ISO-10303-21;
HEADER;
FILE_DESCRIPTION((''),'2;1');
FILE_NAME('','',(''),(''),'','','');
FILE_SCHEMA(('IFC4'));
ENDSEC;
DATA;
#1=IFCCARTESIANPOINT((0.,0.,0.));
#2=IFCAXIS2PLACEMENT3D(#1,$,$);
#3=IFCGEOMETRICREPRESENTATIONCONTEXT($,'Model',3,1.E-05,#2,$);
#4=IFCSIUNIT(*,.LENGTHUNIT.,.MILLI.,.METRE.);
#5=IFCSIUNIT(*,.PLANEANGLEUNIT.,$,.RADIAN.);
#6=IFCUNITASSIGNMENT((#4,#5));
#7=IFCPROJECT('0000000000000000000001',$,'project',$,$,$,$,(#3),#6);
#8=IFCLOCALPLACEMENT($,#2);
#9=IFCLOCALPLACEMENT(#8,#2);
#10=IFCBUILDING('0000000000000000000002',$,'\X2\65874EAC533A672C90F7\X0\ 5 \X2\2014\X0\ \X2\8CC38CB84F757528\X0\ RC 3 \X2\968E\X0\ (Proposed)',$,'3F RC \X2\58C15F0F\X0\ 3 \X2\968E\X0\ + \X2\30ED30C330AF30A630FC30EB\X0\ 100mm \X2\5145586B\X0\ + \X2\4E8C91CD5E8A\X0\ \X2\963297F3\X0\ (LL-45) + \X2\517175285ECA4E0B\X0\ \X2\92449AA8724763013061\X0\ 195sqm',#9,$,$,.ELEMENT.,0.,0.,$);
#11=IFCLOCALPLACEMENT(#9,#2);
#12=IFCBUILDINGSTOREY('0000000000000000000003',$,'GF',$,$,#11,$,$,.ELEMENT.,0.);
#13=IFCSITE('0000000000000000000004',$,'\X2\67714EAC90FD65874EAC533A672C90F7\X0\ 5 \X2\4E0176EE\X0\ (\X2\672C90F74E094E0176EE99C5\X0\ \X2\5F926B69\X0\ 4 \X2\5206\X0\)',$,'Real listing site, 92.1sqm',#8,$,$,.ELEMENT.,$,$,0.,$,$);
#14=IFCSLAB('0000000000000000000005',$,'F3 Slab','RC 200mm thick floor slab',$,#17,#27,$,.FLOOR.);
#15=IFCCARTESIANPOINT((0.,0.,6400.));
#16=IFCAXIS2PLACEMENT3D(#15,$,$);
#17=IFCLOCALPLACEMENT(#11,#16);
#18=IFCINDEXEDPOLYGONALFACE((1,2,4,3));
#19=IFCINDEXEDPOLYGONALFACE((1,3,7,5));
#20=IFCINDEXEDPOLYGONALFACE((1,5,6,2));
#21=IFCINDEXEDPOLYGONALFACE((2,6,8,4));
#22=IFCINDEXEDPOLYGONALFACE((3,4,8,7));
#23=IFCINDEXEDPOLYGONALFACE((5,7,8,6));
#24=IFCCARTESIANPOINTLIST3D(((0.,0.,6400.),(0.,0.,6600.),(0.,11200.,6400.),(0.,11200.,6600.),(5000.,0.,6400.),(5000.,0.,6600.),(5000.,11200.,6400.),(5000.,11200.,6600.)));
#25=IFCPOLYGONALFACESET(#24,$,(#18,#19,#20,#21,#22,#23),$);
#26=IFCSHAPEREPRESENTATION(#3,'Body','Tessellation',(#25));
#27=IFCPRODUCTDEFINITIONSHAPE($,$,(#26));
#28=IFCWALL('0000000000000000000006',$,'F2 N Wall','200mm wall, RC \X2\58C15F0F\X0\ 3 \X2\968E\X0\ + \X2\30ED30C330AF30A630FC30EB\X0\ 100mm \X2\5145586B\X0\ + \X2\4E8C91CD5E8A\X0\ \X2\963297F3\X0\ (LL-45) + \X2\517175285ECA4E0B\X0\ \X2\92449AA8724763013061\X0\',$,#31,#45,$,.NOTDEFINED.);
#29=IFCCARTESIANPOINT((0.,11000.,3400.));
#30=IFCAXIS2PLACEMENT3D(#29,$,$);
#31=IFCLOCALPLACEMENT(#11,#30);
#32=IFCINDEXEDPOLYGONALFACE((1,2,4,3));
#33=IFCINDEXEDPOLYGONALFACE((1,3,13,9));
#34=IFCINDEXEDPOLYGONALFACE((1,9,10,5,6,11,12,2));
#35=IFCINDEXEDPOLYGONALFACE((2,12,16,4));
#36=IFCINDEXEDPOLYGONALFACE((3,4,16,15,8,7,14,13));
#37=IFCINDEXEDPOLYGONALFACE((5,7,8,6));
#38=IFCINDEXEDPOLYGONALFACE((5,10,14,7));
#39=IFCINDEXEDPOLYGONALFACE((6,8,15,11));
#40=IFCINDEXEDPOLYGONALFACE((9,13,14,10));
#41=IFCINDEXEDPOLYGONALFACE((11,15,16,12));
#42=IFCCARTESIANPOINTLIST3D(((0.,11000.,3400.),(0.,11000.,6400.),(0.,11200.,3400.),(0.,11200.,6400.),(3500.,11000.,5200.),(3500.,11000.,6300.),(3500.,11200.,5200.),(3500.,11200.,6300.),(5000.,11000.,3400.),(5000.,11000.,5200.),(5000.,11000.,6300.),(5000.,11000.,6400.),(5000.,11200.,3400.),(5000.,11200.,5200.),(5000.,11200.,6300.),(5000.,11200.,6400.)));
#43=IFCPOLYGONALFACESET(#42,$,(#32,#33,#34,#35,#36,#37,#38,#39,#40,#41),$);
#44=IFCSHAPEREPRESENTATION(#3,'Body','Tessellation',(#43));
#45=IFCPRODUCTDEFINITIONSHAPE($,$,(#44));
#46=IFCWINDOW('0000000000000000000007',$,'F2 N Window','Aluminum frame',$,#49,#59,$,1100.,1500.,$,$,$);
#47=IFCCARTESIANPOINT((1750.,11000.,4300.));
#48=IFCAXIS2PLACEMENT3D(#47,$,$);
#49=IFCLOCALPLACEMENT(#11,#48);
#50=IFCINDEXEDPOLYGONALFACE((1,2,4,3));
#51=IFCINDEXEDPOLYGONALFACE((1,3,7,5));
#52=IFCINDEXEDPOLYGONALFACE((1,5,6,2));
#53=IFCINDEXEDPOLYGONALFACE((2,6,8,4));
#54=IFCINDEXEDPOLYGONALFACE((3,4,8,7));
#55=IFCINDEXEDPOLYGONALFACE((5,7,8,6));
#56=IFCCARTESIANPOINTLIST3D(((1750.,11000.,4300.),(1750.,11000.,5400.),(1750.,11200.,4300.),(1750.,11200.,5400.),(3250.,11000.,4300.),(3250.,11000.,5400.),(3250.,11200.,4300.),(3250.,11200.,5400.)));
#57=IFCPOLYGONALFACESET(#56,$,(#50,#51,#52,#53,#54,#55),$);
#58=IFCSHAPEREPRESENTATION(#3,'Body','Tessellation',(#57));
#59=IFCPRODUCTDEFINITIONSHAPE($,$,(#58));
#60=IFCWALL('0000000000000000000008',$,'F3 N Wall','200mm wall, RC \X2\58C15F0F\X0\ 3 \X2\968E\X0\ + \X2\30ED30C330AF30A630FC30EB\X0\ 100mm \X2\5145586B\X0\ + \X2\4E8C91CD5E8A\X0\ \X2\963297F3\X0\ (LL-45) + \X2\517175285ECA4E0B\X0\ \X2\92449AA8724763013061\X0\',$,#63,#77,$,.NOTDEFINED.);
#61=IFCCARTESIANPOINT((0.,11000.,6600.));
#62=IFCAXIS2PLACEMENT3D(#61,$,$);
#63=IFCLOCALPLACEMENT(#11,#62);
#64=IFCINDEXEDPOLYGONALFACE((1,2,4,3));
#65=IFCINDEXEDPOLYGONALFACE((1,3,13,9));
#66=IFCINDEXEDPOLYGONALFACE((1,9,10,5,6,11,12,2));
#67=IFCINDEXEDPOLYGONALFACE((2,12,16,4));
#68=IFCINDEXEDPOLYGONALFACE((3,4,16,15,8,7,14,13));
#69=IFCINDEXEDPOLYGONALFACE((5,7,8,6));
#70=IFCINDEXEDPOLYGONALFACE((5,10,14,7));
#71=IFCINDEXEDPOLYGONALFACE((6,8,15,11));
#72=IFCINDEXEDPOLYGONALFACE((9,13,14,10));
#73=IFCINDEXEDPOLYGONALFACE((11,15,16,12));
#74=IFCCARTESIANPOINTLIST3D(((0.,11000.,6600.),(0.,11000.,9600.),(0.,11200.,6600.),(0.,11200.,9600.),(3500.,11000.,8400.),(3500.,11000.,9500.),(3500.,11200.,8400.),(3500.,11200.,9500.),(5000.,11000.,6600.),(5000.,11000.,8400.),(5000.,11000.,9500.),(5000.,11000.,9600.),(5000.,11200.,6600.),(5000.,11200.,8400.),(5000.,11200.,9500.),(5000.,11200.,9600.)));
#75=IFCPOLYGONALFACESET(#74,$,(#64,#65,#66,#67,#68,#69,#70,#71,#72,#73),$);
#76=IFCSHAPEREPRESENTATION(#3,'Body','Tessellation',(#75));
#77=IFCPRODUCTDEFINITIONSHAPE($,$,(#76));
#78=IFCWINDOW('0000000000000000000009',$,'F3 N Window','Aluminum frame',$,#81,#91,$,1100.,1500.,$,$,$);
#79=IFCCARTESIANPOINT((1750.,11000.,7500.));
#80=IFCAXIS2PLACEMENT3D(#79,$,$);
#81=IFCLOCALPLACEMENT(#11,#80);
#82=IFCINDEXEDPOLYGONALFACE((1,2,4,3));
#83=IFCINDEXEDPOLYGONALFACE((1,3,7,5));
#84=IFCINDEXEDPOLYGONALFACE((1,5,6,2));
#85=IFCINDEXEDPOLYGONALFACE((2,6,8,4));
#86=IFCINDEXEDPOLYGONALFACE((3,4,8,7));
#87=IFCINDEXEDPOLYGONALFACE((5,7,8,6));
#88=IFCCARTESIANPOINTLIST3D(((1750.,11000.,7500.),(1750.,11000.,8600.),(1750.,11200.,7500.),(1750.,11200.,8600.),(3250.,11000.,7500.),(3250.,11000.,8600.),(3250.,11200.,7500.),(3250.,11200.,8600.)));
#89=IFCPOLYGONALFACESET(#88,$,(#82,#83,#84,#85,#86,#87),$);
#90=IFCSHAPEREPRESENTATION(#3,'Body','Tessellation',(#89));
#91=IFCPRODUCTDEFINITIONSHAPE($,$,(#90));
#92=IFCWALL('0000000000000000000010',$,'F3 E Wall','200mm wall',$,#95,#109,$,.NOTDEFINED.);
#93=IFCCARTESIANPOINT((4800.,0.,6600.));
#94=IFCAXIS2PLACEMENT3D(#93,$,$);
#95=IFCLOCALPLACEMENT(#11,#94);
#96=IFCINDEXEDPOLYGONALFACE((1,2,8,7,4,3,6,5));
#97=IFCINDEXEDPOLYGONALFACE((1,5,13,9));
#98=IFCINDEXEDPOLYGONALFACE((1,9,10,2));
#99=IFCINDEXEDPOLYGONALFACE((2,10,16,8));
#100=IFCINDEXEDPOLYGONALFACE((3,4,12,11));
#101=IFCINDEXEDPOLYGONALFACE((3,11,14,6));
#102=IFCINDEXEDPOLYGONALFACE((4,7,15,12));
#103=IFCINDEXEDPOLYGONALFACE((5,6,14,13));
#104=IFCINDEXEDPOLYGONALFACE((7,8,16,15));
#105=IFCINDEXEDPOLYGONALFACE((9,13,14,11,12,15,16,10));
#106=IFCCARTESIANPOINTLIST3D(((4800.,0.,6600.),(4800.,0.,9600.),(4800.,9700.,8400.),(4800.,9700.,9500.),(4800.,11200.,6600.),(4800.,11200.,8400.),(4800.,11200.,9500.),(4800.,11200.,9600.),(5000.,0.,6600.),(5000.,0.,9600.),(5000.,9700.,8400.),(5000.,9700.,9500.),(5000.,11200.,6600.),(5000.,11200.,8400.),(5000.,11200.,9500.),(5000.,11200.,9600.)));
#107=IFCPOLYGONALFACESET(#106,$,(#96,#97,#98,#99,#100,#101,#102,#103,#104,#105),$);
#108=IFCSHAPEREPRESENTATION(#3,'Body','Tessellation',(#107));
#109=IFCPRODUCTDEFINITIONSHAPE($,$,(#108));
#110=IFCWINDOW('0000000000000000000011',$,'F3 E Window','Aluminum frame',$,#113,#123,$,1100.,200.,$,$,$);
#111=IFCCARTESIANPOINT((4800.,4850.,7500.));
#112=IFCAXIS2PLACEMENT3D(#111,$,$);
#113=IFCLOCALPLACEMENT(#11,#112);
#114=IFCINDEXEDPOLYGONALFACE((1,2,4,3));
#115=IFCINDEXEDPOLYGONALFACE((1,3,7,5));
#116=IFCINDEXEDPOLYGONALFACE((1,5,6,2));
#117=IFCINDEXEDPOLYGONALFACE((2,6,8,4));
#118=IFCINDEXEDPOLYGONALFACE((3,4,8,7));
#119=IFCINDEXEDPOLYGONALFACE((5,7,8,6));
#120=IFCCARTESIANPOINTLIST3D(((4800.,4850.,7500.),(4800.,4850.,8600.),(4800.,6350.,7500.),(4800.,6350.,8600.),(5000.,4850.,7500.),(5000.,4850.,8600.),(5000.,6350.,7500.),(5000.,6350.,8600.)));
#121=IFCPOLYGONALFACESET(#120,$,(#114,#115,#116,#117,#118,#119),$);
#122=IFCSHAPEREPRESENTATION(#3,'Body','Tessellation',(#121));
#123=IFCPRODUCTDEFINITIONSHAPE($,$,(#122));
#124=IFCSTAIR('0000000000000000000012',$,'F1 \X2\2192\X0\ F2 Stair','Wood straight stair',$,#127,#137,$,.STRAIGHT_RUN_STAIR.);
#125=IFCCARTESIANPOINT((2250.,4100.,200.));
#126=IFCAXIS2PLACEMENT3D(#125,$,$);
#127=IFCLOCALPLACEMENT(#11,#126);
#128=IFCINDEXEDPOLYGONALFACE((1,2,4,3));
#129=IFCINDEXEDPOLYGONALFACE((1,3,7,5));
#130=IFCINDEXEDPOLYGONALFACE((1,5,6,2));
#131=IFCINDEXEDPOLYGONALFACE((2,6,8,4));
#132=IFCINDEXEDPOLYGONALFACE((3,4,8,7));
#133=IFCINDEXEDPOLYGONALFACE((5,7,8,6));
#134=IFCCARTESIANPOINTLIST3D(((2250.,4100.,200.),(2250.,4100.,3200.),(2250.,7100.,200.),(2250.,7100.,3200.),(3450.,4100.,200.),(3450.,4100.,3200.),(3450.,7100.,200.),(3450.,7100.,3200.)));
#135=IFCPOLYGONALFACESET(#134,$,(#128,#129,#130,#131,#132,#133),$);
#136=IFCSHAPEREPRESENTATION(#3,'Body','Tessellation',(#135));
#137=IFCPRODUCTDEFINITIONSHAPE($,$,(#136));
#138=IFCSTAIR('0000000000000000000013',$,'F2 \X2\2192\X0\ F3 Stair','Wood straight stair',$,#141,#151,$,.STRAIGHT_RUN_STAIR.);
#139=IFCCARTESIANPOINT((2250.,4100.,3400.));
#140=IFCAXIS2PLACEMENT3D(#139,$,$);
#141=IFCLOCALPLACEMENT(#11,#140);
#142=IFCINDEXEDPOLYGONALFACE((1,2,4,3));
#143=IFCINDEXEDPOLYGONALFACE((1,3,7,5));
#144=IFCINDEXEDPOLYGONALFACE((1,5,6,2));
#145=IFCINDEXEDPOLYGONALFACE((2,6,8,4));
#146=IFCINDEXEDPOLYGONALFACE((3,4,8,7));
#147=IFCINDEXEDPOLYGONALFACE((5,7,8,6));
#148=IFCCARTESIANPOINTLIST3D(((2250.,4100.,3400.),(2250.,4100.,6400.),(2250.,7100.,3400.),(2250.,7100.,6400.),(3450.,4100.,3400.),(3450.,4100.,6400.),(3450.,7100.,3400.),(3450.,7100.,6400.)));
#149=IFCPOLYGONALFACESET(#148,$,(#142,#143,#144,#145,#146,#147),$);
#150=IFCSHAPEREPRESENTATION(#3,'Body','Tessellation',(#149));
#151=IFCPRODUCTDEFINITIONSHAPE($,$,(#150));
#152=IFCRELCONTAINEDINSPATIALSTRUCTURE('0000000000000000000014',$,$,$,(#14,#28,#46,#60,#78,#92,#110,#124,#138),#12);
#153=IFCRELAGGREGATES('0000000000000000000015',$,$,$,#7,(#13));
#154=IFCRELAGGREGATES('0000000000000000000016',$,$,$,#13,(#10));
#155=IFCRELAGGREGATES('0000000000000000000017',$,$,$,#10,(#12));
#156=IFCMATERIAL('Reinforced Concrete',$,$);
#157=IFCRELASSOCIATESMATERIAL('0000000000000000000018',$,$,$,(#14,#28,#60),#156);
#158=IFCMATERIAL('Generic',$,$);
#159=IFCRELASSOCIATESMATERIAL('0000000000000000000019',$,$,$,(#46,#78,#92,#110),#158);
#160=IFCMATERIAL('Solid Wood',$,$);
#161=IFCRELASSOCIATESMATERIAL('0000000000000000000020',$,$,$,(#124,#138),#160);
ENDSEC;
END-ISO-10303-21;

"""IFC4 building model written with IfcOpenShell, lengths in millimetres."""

from ifc_helpers import new_model, si_unit, frame, frame_2d, origin, place, context, project, spatial, rectangle, extrude, material, element, fill, save


model = new_model("IFC4")

# Units and contexts
model_context = context("Model", 3, precision=1e-05, world=origin())
ifc_project = project(units=[si_unit("LENGTHUNIT", "METRE", prefix="MILLI"), si_unit("PLANEANGLEUNIT", "RADIAN")], contexts=[model_context])

# Site, building, storey
site_placement = place(None, origin())
site = spatial("IfcSite", under=ifc_project, at=site_placement, Name="東京都文京区本郷 5 丁目 (本郷三丁目駅 徒歩 4 分)", ObjectType="Real listing site, 92.1sqm", CompositionType="ELEMENT", RefElevation=0.0)
building_placement = place(site_placement, origin())
building = spatial("IfcBuilding", under=site, at=building_placement, Name="文京区本郷 5 — 賃貸併用 RC 3 階 (Proposed)", ObjectType="3F RC 壁式 3 階 + ロックウール 100mm 充填 + 二重床 防音 (LL-45) + 共用廊下 鉄骨片持ち 195sqm", CompositionType="ELEMENT", ElevationOfRefHeight=0.0, ElevationOfTerrain=0.0)
storey_placement = place(building_placement, origin())
storey = spatial("IfcBuildingStorey", under=building, at=storey_placement, Name="GF", CompositionType="ELEMENT", Elevation=0.0)

# Slab
ifc_material_1 = material(Name="Reinforced Concrete")
slab_placement = place(storey_placement, frame((0.0, 0.0, 6400.0)))
element("IfcSlab", 1, at=slab_placement, inside=storey, material=ifc_material_1, Name="F3 Slab", Description="RC 200mm thick floor slab", PredefinedType="FLOOR", context=model_context, shape_type="SweptSolid", body=[
    extrude(rectangle(XDim=5000.0, YDim=11200.0, at=frame_2d((2500.0, 5600.0))), frame((0.0, 0.0, 6400.0)), (0.0, 0.0, 1.0), 200.0),
])

# Walls, openings, windows
ifc_material_2 = material(Name="Generic")
wall_1_placement = place(storey_placement, frame((0.0, 11000.0, 3400.0)))
wall_1 = element("IfcWall", 2, at=wall_1_placement, inside=storey, material=ifc_material_1, Name="F2 N Wall", Description="200mm wall, RC 壁式 3 階 + ロックウール 100mm 充填 + 二重床 防音 (LL-45) + 共用廊下 鉄骨片持ち", PredefinedType="NOTDEFINED", context=model_context, shape_type="SweptSolid", body=[
    extrude(rectangle(XDim=5000.0, YDim=200.0, at=frame_2d((2500.0, 100.0))), frame((0.0, 11000.0, 3400.0)), (0.0, 0.0, 1.0), 3000.0),
])
opening_1_placement = place(storey_placement, frame((1750.0, 11000.0, 4300.0)))
opening_1 = element("IfcOpeningElement", 3, at=opening_1_placement, cuts=wall_1, PredefinedType="NOTDEFINED", context=model_context, shape_type="SweptSolid", body=[
    extrude(rectangle(XDim=1500.0, YDim=200.0, at=frame_2d((750.0, 100.0))), frame((1750.0, 11000.0, 4300.0)), (0.0, 0.0, 1.0), 1100.0),
])
window_1_placement = place(storey_placement, frame((1750.0, 11000.0, 4300.0)))
window_1 = element("IfcWindow", 4, at=window_1_placement, inside=storey, material=ifc_material_2, Name="F2 N Window", Description="Aluminum frame", OverallHeight=1100.0, OverallWidth=1500.0, context=model_context, shape_type="SweptSolid", body=[
    extrude(rectangle(XDim=1500.0, YDim=200.0, at=frame_2d((750.0, 100.0))), frame((1750.0, 11000.0, 4300.0)), (0.0, 0.0, 1.0), 1100.0),
])
fill(opening_1, window_1)
wall_2_placement = place(storey_placement, frame((0.0, 11000.0, 6600.0)))
wall_2 = element("IfcWall", 5, at=wall_2_placement, inside=storey, material=ifc_material_1, Name="F3 N Wall", Description="200mm wall, RC 壁式 3 階 + ロックウール 100mm 充填 + 二重床 防音 (LL-45) + 共用廊下 鉄骨片持ち", PredefinedType="NOTDEFINED", context=model_context, shape_type="SweptSolid", body=[
    extrude(rectangle(XDim=5000.0, YDim=200.0, at=frame_2d((2500.0, 100.0))), frame((0.0, 11000.0, 6600.0)), (0.0, 0.0, 1.0), 3000.0),
])
opening_2_placement = place(storey_placement, frame((1750.0, 11000.0, 7500.0)))
opening_2 = element("IfcOpeningElement", 6, at=opening_2_placement, cuts=wall_2, PredefinedType="NOTDEFINED", context=model_context, shape_type="SweptSolid", body=[
    extrude(rectangle(XDim=1500.0, YDim=200.0, at=frame_2d((750.0, 100.0))), frame((1750.0, 11000.0, 7500.0)), (0.0, 0.0, 1.0), 1100.0),
])
window_2_placement = place(storey_placement, frame((1750.0, 11000.0, 7500.0)))
window_2 = element("IfcWindow", 7, at=window_2_placement, inside=storey, material=ifc_material_2, Name="F3 N Window", Description="Aluminum frame", OverallHeight=1100.0, OverallWidth=1500.0, context=model_context, shape_type="SweptSolid", body=[
    extrude(rectangle(XDim=1500.0, YDim=200.0, at=frame_2d((750.0, 100.0))), frame((1750.0, 11000.0, 7500.0)), (0.0, 0.0, 1.0), 1100.0),
])
fill(opening_2, window_2)
wall_3_placement = place(storey_placement, frame((4800.0, 0.0, 6600.0)))
wall_3 = element("IfcWall", 8, at=wall_3_placement, inside=storey, material=ifc_material_2, Name="F3 E Wall", Description="200mm wall", PredefinedType="NOTDEFINED", context=model_context, shape_type="SweptSolid", body=[
    extrude(rectangle(XDim=200.0, YDim=11200.0, at=frame_2d((100.0, 5600.0))), frame((4800.0, 0.0, 6600.0)), (0.0, 0.0, 1.0), 3000.0),
])
opening_3_placement = place(storey_placement, frame((4800.0, 4850.0, 7500.0)))
opening_3 = element("IfcOpeningElement", 9, at=opening_3_placement, cuts=wall_3, PredefinedType="NOTDEFINED", context=model_context, shape_type="SweptSolid", body=[
    extrude(rectangle(XDim=200.0, YDim=1500.0, at=frame_2d((100.0, 750.0))), frame((4800.0, 4850.0, 7500.0)), (0.0, 0.0, 1.0), 1100.0),
])
window_3_placement = place(storey_placement, frame((4800.0, 4850.0, 7500.0)))
window_3 = element("IfcWindow", 10, at=window_3_placement, inside=storey, material=ifc_material_2, Name="F3 E Window", Description="Aluminum frame", OverallHeight=1100.0, OverallWidth=200.0, context=model_context, shape_type="SweptSolid", body=[
    extrude(rectangle(XDim=200.0, YDim=1500.0, at=frame_2d((100.0, 750.0))), frame((4800.0, 4850.0, 7500.0)), (0.0, 0.0, 1.0), 1100.0),
])
fill(opening_3, window_3)

# Stairs
ifc_material_3 = material(Name="Solid Wood")
stair_1_placement = place(storey_placement, frame((2250.0, 4100.0, 200.0)))
element("IfcStair", 11, at=stair_1_placement, inside=storey, material=ifc_material_3, Name="F1 → F2 Stair", Description="Wood straight stair", PredefinedType="STRAIGHT_RUN_STAIR", context=model_context, shape_type="SweptSolid", body=[
    extrude(rectangle(XDim=1200.0, YDim=3000.0, at=frame_2d((600.0, 1500.0))), frame((2250.0, 4100.0, 200.0)), (0.0, 0.0, 1.0), 3000.0),
])
stair_2_placement = place(storey_placement, frame((2250.0, 4100.0, 3400.0)))
element("IfcStair", 12, at=stair_2_placement, inside=storey, material=ifc_material_3, Name="F2 → F3 Stair", Description="Wood straight stair", PredefinedType="STRAIGHT_RUN_STAIR", context=model_context, shape_type="SweptSolid", body=[
    extrude(rectangle(XDim=1200.0, YDim=3000.0, at=frame_2d((600.0, 1500.0))), frame((2250.0, 4100.0, 3400.0)), (0.0, 0.0, 1.0), 3000.0),
])

save(model, "model.ifc")
